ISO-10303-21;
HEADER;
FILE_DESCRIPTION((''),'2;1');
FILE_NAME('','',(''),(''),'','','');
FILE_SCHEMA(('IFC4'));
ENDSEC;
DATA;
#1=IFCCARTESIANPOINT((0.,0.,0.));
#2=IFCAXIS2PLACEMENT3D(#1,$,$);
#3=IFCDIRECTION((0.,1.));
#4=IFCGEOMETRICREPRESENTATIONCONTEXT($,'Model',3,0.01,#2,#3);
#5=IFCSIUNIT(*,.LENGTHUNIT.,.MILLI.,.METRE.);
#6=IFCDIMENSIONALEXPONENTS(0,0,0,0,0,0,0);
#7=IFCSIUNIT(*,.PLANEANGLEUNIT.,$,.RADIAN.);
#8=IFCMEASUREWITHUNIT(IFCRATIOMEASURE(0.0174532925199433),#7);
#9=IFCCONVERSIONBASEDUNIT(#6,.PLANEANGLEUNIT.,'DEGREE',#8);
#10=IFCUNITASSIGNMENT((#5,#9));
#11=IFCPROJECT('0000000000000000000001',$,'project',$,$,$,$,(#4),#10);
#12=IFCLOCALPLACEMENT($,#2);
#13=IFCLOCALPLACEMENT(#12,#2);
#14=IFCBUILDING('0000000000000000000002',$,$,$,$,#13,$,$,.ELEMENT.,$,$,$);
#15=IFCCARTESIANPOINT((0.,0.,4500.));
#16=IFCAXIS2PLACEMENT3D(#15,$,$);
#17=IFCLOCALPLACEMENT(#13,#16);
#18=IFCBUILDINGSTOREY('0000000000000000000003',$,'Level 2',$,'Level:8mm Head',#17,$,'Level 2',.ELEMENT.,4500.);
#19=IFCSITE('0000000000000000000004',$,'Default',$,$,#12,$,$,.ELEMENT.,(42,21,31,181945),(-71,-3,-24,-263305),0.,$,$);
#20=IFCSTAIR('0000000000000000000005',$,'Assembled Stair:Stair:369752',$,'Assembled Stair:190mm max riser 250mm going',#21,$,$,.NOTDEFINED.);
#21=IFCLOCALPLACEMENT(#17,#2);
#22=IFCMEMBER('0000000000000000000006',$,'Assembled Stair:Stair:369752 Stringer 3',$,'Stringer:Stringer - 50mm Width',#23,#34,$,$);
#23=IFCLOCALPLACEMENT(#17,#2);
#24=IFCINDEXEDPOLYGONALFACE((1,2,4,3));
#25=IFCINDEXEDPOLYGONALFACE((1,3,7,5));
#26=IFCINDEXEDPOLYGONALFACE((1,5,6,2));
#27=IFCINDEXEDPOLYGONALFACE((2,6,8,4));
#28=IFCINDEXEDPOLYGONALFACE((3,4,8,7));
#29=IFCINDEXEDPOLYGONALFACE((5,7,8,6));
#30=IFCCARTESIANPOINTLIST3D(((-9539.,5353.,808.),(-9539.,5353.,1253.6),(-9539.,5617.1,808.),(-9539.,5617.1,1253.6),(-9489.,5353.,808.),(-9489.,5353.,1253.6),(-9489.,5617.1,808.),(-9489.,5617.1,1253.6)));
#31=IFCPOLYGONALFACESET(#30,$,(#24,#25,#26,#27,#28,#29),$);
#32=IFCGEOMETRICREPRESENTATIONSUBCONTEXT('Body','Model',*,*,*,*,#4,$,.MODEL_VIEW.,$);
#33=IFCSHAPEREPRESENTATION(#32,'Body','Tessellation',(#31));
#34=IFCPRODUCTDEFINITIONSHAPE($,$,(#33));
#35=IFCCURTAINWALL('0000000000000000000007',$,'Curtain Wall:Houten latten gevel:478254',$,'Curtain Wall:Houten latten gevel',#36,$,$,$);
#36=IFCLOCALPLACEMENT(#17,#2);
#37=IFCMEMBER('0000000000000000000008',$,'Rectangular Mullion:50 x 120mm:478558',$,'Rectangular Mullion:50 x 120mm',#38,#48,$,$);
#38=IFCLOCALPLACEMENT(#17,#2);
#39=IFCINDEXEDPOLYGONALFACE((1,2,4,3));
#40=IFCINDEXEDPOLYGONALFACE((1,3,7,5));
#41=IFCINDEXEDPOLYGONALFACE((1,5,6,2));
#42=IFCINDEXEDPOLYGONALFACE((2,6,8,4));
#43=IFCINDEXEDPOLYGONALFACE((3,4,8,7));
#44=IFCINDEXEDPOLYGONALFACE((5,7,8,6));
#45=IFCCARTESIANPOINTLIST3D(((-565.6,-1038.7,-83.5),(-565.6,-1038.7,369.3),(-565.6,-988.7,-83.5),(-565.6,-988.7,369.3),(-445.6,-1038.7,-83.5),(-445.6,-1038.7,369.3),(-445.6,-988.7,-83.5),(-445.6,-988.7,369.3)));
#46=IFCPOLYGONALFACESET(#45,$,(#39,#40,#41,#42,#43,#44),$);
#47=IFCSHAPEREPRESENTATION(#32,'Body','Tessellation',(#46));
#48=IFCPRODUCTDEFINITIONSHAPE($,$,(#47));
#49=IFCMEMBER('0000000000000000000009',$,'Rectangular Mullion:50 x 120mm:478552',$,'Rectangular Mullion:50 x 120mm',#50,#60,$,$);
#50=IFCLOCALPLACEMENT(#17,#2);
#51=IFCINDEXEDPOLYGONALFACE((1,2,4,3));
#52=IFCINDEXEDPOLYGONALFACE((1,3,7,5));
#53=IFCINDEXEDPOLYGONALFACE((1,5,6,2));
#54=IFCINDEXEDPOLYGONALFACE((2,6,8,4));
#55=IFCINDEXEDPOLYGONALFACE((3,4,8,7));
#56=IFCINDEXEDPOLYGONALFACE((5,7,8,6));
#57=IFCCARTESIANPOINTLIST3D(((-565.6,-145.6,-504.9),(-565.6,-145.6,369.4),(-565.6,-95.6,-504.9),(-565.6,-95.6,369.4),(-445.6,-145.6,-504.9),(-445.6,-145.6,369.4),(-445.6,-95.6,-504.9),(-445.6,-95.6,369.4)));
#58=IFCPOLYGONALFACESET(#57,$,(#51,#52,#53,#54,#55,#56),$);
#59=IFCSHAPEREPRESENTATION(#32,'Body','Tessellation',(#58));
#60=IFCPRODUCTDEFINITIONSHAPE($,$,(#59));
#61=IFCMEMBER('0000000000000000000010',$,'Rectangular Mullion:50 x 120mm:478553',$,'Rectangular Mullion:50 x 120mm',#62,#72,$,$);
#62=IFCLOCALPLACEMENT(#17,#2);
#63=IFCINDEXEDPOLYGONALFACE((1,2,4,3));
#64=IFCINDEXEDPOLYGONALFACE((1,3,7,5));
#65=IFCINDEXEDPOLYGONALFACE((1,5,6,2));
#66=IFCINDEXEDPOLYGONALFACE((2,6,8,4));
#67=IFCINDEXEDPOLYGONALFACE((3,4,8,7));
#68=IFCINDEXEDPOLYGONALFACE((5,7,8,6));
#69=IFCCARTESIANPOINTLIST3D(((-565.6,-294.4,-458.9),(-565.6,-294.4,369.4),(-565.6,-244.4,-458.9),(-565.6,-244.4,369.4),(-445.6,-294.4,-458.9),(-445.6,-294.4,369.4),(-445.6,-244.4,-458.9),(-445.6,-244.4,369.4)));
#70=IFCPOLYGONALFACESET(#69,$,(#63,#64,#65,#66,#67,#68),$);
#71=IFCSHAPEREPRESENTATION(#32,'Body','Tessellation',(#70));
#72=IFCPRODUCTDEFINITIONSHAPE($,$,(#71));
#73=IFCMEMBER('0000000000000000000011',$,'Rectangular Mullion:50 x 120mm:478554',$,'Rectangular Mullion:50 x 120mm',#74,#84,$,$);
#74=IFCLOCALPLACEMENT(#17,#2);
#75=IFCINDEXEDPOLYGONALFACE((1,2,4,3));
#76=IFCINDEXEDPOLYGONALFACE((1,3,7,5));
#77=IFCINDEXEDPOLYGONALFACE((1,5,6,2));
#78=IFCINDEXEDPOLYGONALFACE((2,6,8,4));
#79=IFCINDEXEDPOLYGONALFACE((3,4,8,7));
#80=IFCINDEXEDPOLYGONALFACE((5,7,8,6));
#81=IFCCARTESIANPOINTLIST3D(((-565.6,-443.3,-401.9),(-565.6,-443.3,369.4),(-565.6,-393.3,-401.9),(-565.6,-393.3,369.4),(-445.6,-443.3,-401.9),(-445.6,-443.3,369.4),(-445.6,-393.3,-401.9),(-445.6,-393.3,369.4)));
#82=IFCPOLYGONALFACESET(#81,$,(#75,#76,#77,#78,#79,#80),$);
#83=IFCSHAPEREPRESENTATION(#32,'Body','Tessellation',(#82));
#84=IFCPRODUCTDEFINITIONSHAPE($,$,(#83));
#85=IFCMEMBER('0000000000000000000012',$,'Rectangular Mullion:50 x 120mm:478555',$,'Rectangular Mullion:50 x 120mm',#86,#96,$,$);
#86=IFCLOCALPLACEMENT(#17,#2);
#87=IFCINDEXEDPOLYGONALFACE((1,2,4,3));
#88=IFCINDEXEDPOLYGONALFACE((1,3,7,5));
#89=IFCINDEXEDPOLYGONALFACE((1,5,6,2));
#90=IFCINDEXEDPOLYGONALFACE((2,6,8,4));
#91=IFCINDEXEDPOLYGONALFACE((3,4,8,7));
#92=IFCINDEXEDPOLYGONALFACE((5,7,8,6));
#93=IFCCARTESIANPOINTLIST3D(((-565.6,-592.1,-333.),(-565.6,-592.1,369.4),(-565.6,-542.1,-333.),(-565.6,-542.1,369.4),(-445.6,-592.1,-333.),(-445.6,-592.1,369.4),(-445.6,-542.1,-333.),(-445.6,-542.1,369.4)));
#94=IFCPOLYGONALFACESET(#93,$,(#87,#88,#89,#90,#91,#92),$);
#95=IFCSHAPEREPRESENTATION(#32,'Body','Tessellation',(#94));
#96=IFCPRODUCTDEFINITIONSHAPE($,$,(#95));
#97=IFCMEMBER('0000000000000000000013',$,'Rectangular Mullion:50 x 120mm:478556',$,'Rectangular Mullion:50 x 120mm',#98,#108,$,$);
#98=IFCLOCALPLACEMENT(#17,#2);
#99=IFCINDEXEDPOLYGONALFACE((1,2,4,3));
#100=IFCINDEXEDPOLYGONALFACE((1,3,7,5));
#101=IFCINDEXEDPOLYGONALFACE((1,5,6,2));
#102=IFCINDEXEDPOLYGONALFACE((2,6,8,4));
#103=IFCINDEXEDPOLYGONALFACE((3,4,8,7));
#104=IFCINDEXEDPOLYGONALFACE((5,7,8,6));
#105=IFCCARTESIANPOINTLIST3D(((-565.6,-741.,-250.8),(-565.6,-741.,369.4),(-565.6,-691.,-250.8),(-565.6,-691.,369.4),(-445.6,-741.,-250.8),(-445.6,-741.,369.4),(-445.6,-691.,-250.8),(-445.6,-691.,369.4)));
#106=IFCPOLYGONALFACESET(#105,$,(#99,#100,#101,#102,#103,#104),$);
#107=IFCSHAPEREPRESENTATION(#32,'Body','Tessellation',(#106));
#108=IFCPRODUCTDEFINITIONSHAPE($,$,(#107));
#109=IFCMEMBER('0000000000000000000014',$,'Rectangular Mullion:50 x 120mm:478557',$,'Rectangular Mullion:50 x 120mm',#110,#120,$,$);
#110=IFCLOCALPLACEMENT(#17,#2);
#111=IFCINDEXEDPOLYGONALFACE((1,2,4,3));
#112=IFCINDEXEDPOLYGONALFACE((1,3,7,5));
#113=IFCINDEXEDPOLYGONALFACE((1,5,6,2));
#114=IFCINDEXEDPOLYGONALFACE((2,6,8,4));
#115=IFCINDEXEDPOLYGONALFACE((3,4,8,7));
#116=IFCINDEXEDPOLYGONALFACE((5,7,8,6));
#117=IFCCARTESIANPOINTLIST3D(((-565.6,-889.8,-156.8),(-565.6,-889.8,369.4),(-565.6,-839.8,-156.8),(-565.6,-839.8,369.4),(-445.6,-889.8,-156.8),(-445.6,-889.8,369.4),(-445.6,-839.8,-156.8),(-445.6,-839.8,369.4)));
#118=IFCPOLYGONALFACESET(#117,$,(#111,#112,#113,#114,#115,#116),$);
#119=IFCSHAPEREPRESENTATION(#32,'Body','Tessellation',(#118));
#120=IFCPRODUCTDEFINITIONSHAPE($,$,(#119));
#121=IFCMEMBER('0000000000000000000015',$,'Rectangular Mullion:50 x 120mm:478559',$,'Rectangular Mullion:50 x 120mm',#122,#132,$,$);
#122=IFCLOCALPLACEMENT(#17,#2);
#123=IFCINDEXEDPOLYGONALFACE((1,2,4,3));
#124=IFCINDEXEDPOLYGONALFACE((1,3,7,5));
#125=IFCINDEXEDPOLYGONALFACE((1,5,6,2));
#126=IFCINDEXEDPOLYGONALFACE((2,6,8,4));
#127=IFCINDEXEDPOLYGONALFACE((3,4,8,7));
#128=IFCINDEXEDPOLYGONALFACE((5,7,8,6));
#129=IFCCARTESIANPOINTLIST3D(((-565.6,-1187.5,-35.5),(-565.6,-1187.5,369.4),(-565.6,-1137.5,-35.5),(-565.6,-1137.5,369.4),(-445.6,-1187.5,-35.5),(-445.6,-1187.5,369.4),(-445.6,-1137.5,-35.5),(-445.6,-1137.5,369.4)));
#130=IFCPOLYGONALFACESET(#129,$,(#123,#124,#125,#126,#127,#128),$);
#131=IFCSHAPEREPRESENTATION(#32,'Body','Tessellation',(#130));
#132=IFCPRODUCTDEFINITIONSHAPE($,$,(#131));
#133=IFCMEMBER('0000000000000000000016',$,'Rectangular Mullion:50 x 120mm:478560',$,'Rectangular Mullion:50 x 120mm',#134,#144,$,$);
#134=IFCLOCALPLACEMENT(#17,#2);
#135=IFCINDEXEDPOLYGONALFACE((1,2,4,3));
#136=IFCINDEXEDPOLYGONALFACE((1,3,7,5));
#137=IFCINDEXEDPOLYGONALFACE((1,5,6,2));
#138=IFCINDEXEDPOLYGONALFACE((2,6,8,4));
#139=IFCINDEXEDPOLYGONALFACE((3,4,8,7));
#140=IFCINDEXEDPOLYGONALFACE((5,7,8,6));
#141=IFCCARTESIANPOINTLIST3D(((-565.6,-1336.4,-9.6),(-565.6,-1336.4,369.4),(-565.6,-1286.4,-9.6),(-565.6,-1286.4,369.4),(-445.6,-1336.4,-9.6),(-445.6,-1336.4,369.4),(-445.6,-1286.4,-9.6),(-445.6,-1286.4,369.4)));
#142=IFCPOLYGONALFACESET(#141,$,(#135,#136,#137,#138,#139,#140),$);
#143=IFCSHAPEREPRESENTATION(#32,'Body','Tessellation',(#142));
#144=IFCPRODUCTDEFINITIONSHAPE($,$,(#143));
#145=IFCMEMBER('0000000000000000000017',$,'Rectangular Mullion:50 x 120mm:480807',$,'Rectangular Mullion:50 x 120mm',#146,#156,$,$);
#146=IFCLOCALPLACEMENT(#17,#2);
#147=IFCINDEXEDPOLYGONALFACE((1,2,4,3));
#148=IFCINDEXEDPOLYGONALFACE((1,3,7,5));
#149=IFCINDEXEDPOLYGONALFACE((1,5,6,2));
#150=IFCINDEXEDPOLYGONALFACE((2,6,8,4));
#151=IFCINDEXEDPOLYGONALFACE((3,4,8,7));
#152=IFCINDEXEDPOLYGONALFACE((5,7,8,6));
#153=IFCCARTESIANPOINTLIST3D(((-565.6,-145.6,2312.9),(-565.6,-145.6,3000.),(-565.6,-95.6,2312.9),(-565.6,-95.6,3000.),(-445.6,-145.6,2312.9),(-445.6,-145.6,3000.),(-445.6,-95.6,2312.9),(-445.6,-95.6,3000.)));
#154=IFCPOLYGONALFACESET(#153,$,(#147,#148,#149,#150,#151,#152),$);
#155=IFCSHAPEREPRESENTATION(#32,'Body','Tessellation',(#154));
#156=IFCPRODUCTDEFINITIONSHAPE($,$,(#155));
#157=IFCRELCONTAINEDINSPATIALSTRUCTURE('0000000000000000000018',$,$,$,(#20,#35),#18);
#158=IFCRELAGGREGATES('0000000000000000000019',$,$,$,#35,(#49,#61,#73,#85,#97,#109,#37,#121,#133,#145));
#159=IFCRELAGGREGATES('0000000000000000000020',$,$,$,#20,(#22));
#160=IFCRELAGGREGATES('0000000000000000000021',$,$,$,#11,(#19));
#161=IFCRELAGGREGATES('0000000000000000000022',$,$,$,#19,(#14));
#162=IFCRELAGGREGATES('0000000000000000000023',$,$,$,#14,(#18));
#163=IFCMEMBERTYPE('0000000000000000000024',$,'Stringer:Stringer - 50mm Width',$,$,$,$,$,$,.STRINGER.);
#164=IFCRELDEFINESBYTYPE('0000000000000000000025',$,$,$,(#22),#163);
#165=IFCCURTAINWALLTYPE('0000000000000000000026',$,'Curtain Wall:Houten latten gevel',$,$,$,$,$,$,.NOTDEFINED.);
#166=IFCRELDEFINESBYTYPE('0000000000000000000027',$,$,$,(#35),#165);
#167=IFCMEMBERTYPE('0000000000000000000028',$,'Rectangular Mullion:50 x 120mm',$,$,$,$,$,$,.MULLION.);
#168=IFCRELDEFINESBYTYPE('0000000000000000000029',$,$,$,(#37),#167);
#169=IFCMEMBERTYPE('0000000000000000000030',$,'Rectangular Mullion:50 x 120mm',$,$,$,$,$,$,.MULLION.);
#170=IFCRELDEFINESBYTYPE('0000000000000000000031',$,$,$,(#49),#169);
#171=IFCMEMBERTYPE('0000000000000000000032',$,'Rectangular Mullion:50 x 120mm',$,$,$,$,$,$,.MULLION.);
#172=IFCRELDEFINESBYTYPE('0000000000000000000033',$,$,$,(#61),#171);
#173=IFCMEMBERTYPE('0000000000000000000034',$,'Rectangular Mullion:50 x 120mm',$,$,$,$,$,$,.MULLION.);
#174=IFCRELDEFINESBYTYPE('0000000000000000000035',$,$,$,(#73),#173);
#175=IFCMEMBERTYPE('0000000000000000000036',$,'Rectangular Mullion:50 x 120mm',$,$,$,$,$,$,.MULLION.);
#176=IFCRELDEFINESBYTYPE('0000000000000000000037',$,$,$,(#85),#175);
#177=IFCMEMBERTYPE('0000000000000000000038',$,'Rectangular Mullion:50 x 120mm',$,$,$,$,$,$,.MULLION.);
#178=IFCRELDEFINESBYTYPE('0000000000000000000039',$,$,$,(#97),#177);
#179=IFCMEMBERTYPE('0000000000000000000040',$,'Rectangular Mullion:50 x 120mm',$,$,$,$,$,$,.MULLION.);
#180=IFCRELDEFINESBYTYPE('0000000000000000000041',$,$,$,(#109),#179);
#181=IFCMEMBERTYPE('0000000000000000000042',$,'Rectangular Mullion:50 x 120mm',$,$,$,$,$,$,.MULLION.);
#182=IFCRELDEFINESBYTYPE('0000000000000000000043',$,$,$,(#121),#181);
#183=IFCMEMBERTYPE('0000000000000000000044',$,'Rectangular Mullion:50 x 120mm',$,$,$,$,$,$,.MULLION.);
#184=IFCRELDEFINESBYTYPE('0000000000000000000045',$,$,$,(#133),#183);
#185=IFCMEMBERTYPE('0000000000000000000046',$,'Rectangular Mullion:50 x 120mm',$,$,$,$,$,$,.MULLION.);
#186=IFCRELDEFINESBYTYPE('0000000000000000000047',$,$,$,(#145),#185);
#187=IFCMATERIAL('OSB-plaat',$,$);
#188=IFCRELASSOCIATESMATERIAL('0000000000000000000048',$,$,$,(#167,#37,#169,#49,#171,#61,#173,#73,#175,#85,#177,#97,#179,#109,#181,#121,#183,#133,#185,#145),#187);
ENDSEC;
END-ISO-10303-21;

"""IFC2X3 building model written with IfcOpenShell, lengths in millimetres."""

from ifc_helpers import new_model, entity, si_unit, converted_unit, direction, frame, frame_2d, origin, origin_2d_with_axis, place, context, subcontext, project, spatial, rectangle, extrude, source, transform, mapped, material, type_object, type_shapes, element, aggregate, save


model = new_model("IFC2X3")

# Units and contexts
model_context = context("Model", 3, precision=0.01, world=origin(), true_north=direction((0.0, 1.0)))
body_context = subcontext(model_context, "Body", "Model", "MODEL_VIEW")
ifc_project = project(units=[si_unit("LENGTHUNIT", "METRE", prefix="MILLI"), converted_unit("PLANEANGLEUNIT", "DEGREE", entity("IfcRatioMeasure", 0.0174532925199433), si_unit("PLANEANGLEUNIT", "RADIAN"), dimensions=[0, 0, 0, 0, 0, 0, 0])], contexts=[model_context])

# Site, building, storey
site_placement = place(None, frame((0.0, 0.0, 0.0)))
site = spatial("IfcSite", under=ifc_project, at=site_placement, Name="Default", CompositionType="ELEMENT", RefLatitude=(42, 21, 31, 181945), RefLongitude=(-71, -3, -24, -263305), RefElevation=0.0)
building_placement = place(site_placement, origin())
building = spatial("IfcBuilding", under=site, at=building_placement, CompositionType="ELEMENT")
storey_placement = place(building_placement, frame((0.0, 0.0, 4500.0)))
storey = spatial("IfcBuildingStorey", under=building, at=storey_placement, Name="Level 2", ObjectType="Level:8mm Head", LongName="Level 2", CompositionType="ELEMENT", Elevation=4500.0)

# Stair, member
stair_placement = place(storey_placement, origin())
stair = element("IfcStair", 1, at=stair_placement, inside=storey, Name="Assembled Stair:Stair:369752", ObjectType="Assembled Stair:190mm max riser 250mm going", ShapeType="NOTDEFINED")
member_type_1 = type_object("IfcMemberType", Name="Stringer:Stringer - 50mm Width", PredefinedType="STRINGER")
member_1_placement = place(stair_placement, origin())
member_1 = element("IfcMember", 2, at=member_1_placement, type_object=member_type_1, Name="Assembled Stair:Stair:369752 Stringer 3", ObjectType="Stringer:Stringer - 50mm Width", context=body_context, shape_type="SweptSolid", body=[
    extrude(rectangle(XDim=264.1, YDim=50.0, at=frame_2d((0.0, 0.0), x_axis=(1.0, 0.0))), frame((-9514.0, 5485.1, 808.0), z_axis=(0.0, 0.0, 1.0), x_axis=(0.0, -1.0, 0.0)), (0.0, 0.0, 1.0), 445.6),
])

# Curtain wall, members
curtain_wall_type = type_object("IfcCurtainWallType", Name="Curtain Wall:Houten latten gevel", PredefinedType="NOTDEFINED")
curtain_wall_placement = place(storey_placement, frame((0.0, 0.0, -4500.0)))
curtain_wall = element("IfcCurtainWall", 3, at=curtain_wall_placement, inside=storey, type_object=curtain_wall_type, Name="Curtain Wall:Houten latten gevel:478254", ObjectType="Curtain Wall:Houten latten gevel")
ifc_material_1 = material(Name="OSB-plaat")
member_type_2 = type_object("IfcMemberType", Name="Rectangular Mullion:50 x 120mm", PredefinedType="MULLION", material=ifc_material_1)
shared_shape_1 = source(origin(), body_context, "Body", "SweptSolid", [
    extrude(rectangle(XDim=120.0, YDim=50.0, at=origin_2d_with_axis()), frame((0.0, 0.0, -452.8), z_axis=(0.0, 0.0, 1.0), x_axis=(0.0, -1.0, 0.0)), (0.0, 0.0, 1.0), 452.8),
])
type_shapes(member_type_2, [shared_shape_1])
member_2_placement = place(storey_placement, frame((-505.6, -1013.7, -83.5), z_axis=(0.0, 0.0, -1.0), x_axis=(0.0, -1.0, 0.0)))
member_2 = element("IfcMember", 4, at=member_2_placement, type_object=member_type_2, material=ifc_material_1, Name="Rectangular Mullion:50 x 120mm:478558", ObjectType="Rectangular Mullion:50 x 120mm", context=body_context, shape_type="MappedRepresentation", body=[
    mapped(shared_shape_1, transform((0.0, 0.0, 0.0), scale=1.0)),
])
member_type_3 = type_object("IfcMemberType", Name="Rectangular Mullion:50 x 120mm", PredefinedType="MULLION", material=ifc_material_1)
shared_shape_2 = source(origin(), body_context, "Body", "SweptSolid", [
    extrude(rectangle(XDim=120.0, YDim=50.0, at=origin_2d_with_axis()), frame((0.0, 0.0, -874.3), z_axis=(0.0, 0.0, 1.0), x_axis=(0.0, -1.0, 0.0)), (0.0, 0.0, 1.0), 874.3),
])
type_shapes(member_type_3, [shared_shape_2])
member_3_placement = place(storey_placement, frame((-505.6, -120.6, -504.9), z_axis=(0.0, 0.0, -1.0), x_axis=(0.0, -1.0, 0.0)))
member_3 = element("IfcMember", 5, at=member_3_placement, type_object=member_type_3, material=ifc_material_1, Name="Rectangular Mullion:50 x 120mm:478552", ObjectType="Rectangular Mullion:50 x 120mm", context=body_context, shape_type="MappedRepresentation", body=[
    mapped(shared_shape_2, transform((0.0, 0.0, 0.0), scale=1.0)),
])
member_type_4 = type_object("IfcMemberType", Name="Rectangular Mullion:50 x 120mm", PredefinedType="MULLION", material=ifc_material_1)
shared_shape_3 = source(origin(), body_context, "Body", "SweptSolid", [
    extrude(rectangle(XDim=120.0, YDim=50.0, at=origin_2d_with_axis()), frame((0.0, 0.0, -828.3), z_axis=(0.0, 0.0, 1.0), x_axis=(0.0, -1.0, 0.0)), (0.0, 0.0, 1.0), 828.3),
])
type_shapes(member_type_4, [shared_shape_3])
member_4_placement = place(storey_placement, frame((-505.6, -269.4, -458.9), z_axis=(0.0, 0.0, -1.0), x_axis=(0.0, -1.0, 0.0)))
member_4 = element("IfcMember", 6, at=member_4_placement, type_object=member_type_4, material=ifc_material_1, Name="Rectangular Mullion:50 x 120mm:478553", ObjectType="Rectangular Mullion:50 x 120mm", context=body_context, shape_type="MappedRepresentation", body=[
    mapped(shared_shape_3, transform((0.0, 0.0, 0.0), scale=1.0)),
])
member_type_5 = type_object("IfcMemberType", Name="Rectangular Mullion:50 x 120mm", PredefinedType="MULLION", material=ifc_material_1)
shared_shape_4 = source(origin(), body_context, "Body", "SweptSolid", [
    extrude(rectangle(XDim=120.0, YDim=50.0, at=origin_2d_with_axis()), frame((0.0, 0.0, -771.3), z_axis=(0.0, 0.0, 1.0), x_axis=(0.0, -1.0, 0.0)), (0.0, 0.0, 1.0), 771.3),
])
type_shapes(member_type_5, [shared_shape_4])
member_5_placement = place(storey_placement, frame((-505.6, -418.3, -401.9), z_axis=(0.0, 0.0, -1.0), x_axis=(0.0, -1.0, 0.0)))
member_5 = element("IfcMember", 7, at=member_5_placement, type_object=member_type_5, material=ifc_material_1, Name="Rectangular Mullion:50 x 120mm:478554", ObjectType="Rectangular Mullion:50 x 120mm", context=body_context, shape_type="MappedRepresentation", body=[
    mapped(shared_shape_4, transform((0.0, 0.0, 0.0), scale=1.0)),
])
member_type_6 = type_object("IfcMemberType", Name="Rectangular Mullion:50 x 120mm", PredefinedType="MULLION", material=ifc_material_1)
shared_shape_5 = source(origin(), body_context, "Body", "SweptSolid", [
    extrude(rectangle(XDim=120.0, YDim=50.0, at=origin_2d_with_axis()), frame((0.0, 0.0, -702.3), z_axis=(0.0, 0.0, 1.0), x_axis=(0.0, -1.0, 0.0)), (0.0, 0.0, 1.0), 702.3),
])
type_shapes(member_type_6, [shared_shape_5])
member_6_placement = place(storey_placement, frame((-505.6, -567.1, -333.0), z_axis=(0.0, 0.0, -1.0), x_axis=(0.0, -1.0, 0.0)))
member_6 = element("IfcMember", 8, at=member_6_placement, type_object=member_type_6, material=ifc_material_1, Name="Rectangular Mullion:50 x 120mm:478555", ObjectType="Rectangular Mullion:50 x 120mm", context=body_context, shape_type="MappedRepresentation", body=[
    mapped(shared_shape_5, transform((0.0, 0.0, 0.0), scale=1.0)),
])
member_type_7 = type_object("IfcMemberType", Name="Rectangular Mullion:50 x 120mm", PredefinedType="MULLION", material=ifc_material_1)
shared_shape_6 = source(origin(), body_context, "Body", "SweptSolid", [
    extrude(rectangle(XDim=120.0, YDim=50.0, at=origin_2d_with_axis()), frame((0.0, 0.0, -620.2), z_axis=(0.0, 0.0, 1.0), x_axis=(0.0, -1.0, 0.0)), (0.0, 0.0, 1.0), 620.2),
])
type_shapes(member_type_7, [shared_shape_6])
member_7_placement = place(storey_placement, frame((-505.6, -716.0, -250.8), z_axis=(0.0, 0.0, -1.0), x_axis=(0.0, -1.0, 0.0)))
member_7 = element("IfcMember", 9, at=member_7_placement, type_object=member_type_7, material=ifc_material_1, Name="Rectangular Mullion:50 x 120mm:478556", ObjectType="Rectangular Mullion:50 x 120mm", context=body_context, shape_type="MappedRepresentation", body=[
    mapped(shared_shape_6, transform((0.0, 0.0, 0.0), scale=1.0)),
])
member_type_8 = type_object("IfcMemberType", Name="Rectangular Mullion:50 x 120mm", PredefinedType="MULLION", material=ifc_material_1)
shared_shape_7 = source(origin(), body_context, "Body", "SweptSolid", [
    extrude(rectangle(XDim=120.0, YDim=50.0, at=origin_2d_with_axis()), frame((0.0, 0.0, -526.2), z_axis=(0.0, 0.0, 1.0), x_axis=(0.0, -1.0, 0.0)), (0.0, 0.0, 1.0), 526.2),
])
type_shapes(member_type_8, [shared_shape_7])
member_8_placement = place(storey_placement, frame((-505.6, -864.8, -156.8), z_axis=(0.0, 0.0, -1.0), x_axis=(0.0, -1.0, 0.0)))
member_8 = element("IfcMember", 10, at=member_8_placement, type_object=member_type_8, material=ifc_material_1, Name="Rectangular Mullion:50 x 120mm:478557", ObjectType="Rectangular Mullion:50 x 120mm", context=body_context, shape_type="MappedRepresentation", body=[
    mapped(shared_shape_7, transform((0.0, 0.0, 0.0), scale=1.0)),
])
member_type_9 = type_object("IfcMemberType", Name="Rectangular Mullion:50 x 120mm", PredefinedType="MULLION", material=ifc_material_1)
shared_shape_8 = source(origin(), body_context, "Body", "SweptSolid", [
    extrude(rectangle(XDim=120.0, YDim=50.0, at=origin_2d_with_axis()), frame((0.0, 0.0, -404.9), z_axis=(0.0, 0.0, 1.0), x_axis=(0.0, -1.0, 0.0)), (0.0, 0.0, 1.0), 404.9),
])
type_shapes(member_type_9, [shared_shape_8])
member_9_placement = place(storey_placement, frame((-505.6, -1162.5, -35.5), z_axis=(0.0, 0.0, -1.0), x_axis=(0.0, -1.0, 0.0)))
member_9 = element("IfcMember", 11, at=member_9_placement, type_object=member_type_9, material=ifc_material_1, Name="Rectangular Mullion:50 x 120mm:478559", ObjectType="Rectangular Mullion:50 x 120mm", context=body_context, shape_type="MappedRepresentation", body=[
    mapped(shared_shape_8, transform((0.0, 0.0, 0.0), scale=1.0)),
])
member_type_10 = type_object("IfcMemberType", Name="Rectangular Mullion:50 x 120mm", PredefinedType="MULLION", material=ifc_material_1)
shared_shape_9 = source(origin(), body_context, "Body", "SweptSolid", [
    extrude(rectangle(XDim=120.0, YDim=50.0, at=origin_2d_with_axis()), frame((0.0, 0.0, -379.0), z_axis=(0.0, 0.0, 1.0), x_axis=(0.0, -1.0, 0.0)), (0.0, 0.0, 1.0), 379.0),
])
type_shapes(member_type_10, [shared_shape_9])
member_10_placement = place(storey_placement, frame((-505.6, -1311.4, -9.6), z_axis=(0.0, 0.0, -1.0), x_axis=(0.0, -1.0, 0.0)))
member_10 = element("IfcMember", 12, at=member_10_placement, type_object=member_type_10, material=ifc_material_1, Name="Rectangular Mullion:50 x 120mm:478560", ObjectType="Rectangular Mullion:50 x 120mm", context=body_context, shape_type="MappedRepresentation", body=[
    mapped(shared_shape_9, transform((0.0, 0.0, 0.0), scale=1.0)),
])
member_type_11 = type_object("IfcMemberType", Name="Rectangular Mullion:50 x 120mm", PredefinedType="MULLION", material=ifc_material_1)
shared_shape_10 = source(origin(), body_context, "Body", "SweptSolid", [
    extrude(rectangle(XDim=120.0, YDim=50.0, at=origin_2d_with_axis()), frame((0.0, 0.0, -687.1), z_axis=(0.0, 0.0, 1.0), x_axis=(0.0, -1.0, 0.0)), (0.0, 0.0, 1.0), 687.1),
])
type_shapes(member_type_11, [shared_shape_10])
member_11_placement = place(storey_placement, frame((-505.6, -120.6, 2312.9), z_axis=(0.0, 0.0, -1.0), x_axis=(0.0, -1.0, 0.0)))
member_11 = element("IfcMember", 13, at=member_11_placement, type_object=member_type_11, material=ifc_material_1, Name="Rectangular Mullion:50 x 120mm:480807", ObjectType="Rectangular Mullion:50 x 120mm", context=body_context, shape_type="MappedRepresentation", body=[
    mapped(shared_shape_10, transform((0.0, 0.0, 0.0), scale=1.0)),
])
aggregate(curtain_wall, [member_3, member_4, member_5, member_6, member_7, member_8, member_2, member_9, member_10, member_11])

aggregate(stair, [member_1])

save(model, "model.ifc")
